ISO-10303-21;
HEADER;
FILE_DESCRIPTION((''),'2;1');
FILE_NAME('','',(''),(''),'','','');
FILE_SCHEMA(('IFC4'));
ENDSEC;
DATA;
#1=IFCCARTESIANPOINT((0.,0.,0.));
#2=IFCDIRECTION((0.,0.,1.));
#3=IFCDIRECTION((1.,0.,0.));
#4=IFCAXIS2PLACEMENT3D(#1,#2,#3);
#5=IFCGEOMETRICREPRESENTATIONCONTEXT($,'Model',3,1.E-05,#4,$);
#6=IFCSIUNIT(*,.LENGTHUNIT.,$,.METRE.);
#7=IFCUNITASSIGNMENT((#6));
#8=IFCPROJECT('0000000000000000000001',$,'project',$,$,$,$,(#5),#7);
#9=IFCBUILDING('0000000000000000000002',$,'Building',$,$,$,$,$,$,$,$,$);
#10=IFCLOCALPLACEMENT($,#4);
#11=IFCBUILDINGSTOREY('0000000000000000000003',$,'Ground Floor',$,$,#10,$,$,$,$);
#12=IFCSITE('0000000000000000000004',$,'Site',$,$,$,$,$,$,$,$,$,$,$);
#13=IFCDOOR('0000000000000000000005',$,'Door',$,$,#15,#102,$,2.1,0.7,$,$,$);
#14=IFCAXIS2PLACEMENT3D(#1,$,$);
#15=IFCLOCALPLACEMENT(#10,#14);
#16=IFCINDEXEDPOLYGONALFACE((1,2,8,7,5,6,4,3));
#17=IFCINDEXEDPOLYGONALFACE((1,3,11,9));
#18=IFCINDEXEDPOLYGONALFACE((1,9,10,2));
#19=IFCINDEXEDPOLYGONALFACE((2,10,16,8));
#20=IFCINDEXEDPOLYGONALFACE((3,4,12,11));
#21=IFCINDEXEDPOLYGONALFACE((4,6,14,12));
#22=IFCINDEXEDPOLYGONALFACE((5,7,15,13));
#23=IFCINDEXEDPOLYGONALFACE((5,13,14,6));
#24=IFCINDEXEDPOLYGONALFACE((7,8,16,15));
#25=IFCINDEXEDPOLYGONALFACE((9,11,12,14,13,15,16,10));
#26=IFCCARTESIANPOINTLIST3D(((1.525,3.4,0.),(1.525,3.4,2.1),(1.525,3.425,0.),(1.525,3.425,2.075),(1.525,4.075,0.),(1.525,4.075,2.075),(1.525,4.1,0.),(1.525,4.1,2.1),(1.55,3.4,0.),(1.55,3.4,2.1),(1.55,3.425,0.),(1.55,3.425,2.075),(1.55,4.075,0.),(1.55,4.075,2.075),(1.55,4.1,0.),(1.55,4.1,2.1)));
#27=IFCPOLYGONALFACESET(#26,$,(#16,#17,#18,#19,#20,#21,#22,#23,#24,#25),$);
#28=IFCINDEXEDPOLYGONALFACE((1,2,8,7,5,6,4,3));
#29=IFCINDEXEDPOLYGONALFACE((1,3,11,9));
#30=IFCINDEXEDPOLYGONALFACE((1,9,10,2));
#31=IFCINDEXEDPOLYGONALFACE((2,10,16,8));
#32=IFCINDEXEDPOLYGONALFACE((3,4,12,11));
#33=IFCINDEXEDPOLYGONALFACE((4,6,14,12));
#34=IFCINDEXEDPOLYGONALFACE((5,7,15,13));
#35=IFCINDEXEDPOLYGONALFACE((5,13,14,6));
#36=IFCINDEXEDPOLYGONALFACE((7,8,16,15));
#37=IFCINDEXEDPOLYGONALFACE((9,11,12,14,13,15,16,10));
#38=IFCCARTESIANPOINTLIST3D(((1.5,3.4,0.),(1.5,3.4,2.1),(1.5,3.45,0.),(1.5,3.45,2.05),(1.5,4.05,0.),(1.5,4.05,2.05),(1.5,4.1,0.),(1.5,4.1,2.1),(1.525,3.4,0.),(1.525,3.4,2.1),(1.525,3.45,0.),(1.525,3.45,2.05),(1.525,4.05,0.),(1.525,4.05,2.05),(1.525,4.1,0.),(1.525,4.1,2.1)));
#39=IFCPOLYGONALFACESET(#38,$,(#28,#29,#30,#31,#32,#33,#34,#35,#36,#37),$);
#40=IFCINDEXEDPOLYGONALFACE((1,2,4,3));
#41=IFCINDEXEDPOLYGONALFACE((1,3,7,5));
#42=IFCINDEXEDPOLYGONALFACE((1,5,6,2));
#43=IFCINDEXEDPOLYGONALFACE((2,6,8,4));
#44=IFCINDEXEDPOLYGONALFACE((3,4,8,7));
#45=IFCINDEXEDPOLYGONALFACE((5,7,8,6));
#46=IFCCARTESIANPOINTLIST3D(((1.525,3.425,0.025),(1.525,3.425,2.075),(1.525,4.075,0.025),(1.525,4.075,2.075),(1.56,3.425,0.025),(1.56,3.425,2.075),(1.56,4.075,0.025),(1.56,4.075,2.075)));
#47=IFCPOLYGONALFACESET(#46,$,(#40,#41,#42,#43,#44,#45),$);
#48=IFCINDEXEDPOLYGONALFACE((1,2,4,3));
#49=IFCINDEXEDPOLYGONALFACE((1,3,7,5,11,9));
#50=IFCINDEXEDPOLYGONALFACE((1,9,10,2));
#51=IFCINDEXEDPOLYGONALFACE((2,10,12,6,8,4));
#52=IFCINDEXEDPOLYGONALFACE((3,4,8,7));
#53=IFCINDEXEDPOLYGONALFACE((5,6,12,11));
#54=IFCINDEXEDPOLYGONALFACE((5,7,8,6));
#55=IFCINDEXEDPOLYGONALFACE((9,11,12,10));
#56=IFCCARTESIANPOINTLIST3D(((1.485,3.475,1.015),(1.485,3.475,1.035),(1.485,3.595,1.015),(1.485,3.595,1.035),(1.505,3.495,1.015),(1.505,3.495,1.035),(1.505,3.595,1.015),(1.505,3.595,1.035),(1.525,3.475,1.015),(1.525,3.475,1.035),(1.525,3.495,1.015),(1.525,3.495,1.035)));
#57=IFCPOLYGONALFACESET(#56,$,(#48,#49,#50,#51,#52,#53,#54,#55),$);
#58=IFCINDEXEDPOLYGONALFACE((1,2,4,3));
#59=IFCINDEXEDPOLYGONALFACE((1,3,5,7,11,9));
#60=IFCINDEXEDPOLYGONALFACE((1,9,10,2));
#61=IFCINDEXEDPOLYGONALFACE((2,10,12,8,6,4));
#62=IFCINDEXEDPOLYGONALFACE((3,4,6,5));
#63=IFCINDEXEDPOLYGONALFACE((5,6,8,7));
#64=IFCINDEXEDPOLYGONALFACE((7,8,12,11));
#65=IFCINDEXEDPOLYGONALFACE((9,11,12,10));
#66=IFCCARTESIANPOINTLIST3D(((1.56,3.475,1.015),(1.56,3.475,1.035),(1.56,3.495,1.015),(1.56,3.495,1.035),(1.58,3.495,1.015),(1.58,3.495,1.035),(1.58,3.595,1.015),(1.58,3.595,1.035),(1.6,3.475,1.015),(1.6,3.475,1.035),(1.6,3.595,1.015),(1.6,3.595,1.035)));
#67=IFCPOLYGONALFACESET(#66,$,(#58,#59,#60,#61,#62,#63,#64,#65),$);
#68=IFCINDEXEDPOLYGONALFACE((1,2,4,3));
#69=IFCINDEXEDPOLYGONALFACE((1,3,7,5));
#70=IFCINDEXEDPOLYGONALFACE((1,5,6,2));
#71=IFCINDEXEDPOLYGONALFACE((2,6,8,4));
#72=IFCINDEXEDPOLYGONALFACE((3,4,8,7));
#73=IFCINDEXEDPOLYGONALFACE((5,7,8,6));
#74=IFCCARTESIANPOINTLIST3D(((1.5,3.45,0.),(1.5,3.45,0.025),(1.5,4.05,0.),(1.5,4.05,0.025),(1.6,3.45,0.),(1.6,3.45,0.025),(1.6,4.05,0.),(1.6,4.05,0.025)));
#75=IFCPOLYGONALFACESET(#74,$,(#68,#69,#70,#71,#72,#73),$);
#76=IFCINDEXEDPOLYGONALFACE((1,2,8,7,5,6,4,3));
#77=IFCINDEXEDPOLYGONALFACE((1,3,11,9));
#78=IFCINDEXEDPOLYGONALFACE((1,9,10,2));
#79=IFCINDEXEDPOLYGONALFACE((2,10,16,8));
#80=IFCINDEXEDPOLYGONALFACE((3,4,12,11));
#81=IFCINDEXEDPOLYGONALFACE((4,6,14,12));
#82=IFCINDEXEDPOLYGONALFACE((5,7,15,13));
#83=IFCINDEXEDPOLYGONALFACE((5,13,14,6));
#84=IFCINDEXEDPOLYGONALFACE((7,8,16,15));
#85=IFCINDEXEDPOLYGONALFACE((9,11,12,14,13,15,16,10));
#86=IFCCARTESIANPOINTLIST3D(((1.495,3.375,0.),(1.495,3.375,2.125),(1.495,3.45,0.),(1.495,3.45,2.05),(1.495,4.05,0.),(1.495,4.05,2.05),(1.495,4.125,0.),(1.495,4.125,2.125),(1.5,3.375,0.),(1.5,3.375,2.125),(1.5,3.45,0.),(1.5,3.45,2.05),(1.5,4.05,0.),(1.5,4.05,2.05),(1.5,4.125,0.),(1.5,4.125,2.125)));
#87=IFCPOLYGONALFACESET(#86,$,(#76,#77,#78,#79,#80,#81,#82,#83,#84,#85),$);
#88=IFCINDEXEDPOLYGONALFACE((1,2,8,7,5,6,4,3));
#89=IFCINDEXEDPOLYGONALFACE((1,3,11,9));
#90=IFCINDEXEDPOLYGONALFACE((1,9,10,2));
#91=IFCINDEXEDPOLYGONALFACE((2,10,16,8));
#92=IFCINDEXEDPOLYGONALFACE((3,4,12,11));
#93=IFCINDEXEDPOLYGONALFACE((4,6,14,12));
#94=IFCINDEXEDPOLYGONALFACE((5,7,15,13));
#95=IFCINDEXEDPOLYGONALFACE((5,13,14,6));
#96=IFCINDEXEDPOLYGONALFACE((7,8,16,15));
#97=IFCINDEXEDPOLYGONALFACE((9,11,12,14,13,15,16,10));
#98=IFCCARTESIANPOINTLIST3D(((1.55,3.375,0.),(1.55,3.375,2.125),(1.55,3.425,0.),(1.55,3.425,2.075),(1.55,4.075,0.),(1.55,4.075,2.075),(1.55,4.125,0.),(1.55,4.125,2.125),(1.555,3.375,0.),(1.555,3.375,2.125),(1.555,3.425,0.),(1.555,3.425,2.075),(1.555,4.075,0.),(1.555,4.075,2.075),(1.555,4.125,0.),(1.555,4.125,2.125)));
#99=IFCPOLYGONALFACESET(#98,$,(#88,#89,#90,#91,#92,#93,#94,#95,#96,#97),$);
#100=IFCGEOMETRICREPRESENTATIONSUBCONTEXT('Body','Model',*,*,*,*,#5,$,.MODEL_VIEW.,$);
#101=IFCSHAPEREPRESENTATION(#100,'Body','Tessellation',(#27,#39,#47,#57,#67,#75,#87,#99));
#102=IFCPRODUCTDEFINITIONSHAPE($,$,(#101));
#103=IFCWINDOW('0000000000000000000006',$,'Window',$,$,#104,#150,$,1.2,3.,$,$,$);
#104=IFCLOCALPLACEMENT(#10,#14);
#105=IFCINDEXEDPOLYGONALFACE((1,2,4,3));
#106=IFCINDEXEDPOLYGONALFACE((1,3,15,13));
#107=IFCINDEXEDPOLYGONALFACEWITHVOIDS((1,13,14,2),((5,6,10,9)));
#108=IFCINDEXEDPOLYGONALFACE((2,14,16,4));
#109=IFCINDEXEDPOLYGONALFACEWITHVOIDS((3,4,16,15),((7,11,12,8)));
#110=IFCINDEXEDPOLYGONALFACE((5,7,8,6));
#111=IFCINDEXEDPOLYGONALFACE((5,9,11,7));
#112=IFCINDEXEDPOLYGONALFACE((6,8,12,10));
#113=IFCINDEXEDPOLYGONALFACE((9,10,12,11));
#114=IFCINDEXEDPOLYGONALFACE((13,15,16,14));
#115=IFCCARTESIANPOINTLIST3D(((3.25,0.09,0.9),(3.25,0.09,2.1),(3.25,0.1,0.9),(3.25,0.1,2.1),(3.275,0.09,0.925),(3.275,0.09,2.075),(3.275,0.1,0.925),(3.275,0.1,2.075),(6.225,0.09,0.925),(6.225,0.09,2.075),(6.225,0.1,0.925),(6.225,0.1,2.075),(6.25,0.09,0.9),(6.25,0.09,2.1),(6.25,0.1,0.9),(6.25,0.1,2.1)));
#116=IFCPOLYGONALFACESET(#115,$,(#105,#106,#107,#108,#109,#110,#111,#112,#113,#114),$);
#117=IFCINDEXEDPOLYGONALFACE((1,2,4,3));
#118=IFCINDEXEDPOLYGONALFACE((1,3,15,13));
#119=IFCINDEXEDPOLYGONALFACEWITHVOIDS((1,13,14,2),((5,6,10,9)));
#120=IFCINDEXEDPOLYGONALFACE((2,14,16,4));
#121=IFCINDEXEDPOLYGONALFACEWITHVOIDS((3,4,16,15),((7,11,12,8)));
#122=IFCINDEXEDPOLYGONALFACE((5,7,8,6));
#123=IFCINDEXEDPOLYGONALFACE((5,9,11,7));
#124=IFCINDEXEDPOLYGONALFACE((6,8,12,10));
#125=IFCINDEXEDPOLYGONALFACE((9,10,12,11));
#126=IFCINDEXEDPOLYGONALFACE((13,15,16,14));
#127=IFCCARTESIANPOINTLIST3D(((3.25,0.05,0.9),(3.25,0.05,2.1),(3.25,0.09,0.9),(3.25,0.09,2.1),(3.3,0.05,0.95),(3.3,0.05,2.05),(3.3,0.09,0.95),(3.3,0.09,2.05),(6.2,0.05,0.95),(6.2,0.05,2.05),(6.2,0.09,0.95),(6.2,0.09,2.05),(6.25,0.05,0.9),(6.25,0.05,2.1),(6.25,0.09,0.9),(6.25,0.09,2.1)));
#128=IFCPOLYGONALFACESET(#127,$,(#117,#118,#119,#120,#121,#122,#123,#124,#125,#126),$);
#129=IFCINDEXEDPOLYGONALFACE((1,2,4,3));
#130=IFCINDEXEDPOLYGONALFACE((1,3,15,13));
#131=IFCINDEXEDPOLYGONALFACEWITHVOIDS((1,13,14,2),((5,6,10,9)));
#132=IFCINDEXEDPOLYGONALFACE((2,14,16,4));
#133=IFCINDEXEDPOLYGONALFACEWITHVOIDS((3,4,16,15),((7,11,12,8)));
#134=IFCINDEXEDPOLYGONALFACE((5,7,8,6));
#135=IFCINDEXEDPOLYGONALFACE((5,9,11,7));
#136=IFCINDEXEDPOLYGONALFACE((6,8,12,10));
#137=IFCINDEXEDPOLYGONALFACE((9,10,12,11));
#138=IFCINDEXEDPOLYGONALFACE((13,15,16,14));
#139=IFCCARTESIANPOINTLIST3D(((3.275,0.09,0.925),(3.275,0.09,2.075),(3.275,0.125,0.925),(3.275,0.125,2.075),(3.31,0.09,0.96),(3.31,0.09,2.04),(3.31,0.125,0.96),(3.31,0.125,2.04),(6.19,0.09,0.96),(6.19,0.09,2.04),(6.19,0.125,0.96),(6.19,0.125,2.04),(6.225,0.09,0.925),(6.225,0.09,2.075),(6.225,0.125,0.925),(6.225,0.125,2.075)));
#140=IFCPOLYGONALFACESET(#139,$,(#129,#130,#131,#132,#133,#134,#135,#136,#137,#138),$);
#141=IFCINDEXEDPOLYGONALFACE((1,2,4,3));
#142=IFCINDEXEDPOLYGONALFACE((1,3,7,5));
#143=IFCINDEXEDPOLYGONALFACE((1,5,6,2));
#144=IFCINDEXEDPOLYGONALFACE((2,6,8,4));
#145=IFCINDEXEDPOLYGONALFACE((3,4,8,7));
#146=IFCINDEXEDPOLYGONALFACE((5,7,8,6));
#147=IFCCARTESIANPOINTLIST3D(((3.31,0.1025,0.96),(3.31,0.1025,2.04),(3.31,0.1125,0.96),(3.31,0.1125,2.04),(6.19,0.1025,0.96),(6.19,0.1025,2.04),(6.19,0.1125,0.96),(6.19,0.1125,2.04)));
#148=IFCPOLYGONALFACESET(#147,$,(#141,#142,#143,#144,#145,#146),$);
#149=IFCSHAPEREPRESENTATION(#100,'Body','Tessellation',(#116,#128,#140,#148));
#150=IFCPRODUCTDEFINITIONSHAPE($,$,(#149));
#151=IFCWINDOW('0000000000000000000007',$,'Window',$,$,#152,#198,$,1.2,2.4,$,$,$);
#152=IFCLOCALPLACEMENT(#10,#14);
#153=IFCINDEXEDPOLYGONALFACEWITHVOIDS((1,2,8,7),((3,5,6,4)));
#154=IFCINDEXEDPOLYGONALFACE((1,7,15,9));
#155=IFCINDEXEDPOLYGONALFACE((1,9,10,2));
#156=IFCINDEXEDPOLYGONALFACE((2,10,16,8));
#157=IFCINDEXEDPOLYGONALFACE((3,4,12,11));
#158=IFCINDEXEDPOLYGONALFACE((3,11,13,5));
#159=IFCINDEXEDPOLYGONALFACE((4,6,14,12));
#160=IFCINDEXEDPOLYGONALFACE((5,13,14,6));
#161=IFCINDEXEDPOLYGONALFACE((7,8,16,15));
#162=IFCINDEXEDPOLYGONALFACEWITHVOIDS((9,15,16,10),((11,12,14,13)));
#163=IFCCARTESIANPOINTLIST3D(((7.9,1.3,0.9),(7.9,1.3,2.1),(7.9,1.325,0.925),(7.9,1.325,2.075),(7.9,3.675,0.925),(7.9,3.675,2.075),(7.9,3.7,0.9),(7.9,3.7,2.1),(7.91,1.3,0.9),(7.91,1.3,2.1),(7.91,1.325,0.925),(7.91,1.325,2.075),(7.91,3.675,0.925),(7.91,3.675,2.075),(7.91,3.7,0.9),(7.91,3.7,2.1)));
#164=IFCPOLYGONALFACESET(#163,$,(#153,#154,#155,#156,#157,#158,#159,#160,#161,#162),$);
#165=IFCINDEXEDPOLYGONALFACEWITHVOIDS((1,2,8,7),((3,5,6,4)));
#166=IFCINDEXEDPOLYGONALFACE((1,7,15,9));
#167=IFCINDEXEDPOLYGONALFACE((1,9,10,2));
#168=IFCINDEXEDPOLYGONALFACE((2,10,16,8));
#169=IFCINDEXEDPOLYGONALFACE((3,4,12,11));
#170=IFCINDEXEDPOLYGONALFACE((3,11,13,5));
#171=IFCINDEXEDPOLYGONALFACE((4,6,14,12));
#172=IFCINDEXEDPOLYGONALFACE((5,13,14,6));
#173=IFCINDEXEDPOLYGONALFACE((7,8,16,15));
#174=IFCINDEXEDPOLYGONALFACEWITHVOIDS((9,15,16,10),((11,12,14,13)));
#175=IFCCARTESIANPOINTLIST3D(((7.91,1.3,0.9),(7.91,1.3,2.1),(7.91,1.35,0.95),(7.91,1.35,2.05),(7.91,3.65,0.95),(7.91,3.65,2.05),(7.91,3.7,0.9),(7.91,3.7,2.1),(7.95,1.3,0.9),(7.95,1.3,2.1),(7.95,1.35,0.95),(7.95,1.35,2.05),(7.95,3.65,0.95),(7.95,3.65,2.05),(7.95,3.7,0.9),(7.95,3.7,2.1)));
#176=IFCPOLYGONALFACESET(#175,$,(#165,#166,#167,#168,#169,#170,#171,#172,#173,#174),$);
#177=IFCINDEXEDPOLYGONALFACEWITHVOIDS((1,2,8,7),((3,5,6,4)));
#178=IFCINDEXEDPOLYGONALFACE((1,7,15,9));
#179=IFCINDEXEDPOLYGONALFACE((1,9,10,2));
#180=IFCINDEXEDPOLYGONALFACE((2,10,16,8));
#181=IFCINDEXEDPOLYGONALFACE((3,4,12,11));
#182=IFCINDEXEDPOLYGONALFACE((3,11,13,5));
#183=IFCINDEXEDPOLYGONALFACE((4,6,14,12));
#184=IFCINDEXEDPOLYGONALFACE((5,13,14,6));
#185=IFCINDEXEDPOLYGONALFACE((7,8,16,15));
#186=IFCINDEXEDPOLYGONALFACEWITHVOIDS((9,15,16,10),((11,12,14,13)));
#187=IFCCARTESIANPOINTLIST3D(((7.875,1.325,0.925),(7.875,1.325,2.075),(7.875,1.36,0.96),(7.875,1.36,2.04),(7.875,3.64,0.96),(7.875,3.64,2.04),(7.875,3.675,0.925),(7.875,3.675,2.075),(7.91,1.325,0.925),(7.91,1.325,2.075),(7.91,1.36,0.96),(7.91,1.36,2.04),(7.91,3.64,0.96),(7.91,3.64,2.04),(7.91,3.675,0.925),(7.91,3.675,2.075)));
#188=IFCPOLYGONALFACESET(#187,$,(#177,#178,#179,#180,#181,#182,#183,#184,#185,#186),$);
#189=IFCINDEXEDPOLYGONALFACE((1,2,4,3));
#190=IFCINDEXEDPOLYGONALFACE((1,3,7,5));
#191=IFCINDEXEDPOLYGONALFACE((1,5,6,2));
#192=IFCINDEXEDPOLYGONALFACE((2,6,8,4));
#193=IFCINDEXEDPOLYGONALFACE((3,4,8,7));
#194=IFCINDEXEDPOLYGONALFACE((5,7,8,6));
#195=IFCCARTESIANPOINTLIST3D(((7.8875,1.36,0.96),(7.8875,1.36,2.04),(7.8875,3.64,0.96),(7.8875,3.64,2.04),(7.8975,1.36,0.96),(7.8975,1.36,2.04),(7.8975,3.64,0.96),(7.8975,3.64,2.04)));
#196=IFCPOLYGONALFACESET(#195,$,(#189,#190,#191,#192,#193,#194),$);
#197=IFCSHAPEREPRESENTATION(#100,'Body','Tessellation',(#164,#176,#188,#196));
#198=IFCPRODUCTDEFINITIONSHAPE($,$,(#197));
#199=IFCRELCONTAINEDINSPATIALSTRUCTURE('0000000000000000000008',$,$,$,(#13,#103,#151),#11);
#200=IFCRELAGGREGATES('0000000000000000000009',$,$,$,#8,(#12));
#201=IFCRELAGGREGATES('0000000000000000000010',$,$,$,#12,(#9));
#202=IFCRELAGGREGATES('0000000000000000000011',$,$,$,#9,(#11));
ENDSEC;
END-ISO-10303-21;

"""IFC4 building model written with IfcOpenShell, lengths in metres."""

from ifc_helpers import new_model, si_unit, frame, origin_with_axes, place, context, subcontext, project, spatial, line, indexed_curve, outline, extrude, element, save


model = new_model("IFC4")

# Units and contexts
model_context = context("Model", 3, precision=1e-05, world=origin_with_axes())
body_context = subcontext(model_context, "Body", "Model", "MODEL_VIEW")
ifc_project = project(units=[si_unit("LENGTHUNIT", "METRE")], contexts=[model_context])

# Site, building, storey
site = spatial("IfcSite", under=ifc_project, Name="Site")
building = spatial("IfcBuilding", under=site, Name="Building")
storey_placement = place(None, origin_with_axes())
storey = spatial("IfcBuildingStorey", under=building, at=storey_placement, Name="Ground Floor")

# Door
door_1_placement = place(storey_placement, frame((1.5, 4.1, 0.0), z_axis=(0.0, 0.0, 1.0), x_axis=(0.0, -1.0, 0.0)))
element("IfcDoor", 1, at=door_1_placement, inside=storey, Name="Door", OverallHeight=2.1, OverallWidth=0.7, context=body_context, shape_type="SweptSolid", body=[
    extrude(outline(indexed_curve([(0.0, 0.0), (0.0, 2.1), (0.7, 2.1), (0.7, 0.0), (0.675, 0.0), (0.675, 2.075), (0.025, 2.075), (0.025, 0.0)], segments=[line(1, 2, 3, 4, 5, 6, 7, 8, 1)])), frame((0.0, 0.025, 0.0), z_axis=(0.0, -1.0, 0.0), x_axis=(1.0, 0.0, 0.0)), (0.0, 0.0, -1.0), 0.025),
    extrude(outline(indexed_curve([(0.0, 0.0), (0.0, 2.1), (0.7, 2.1), (0.7, 0.0), (0.65, 0.0), (0.65, 2.05), (0.05, 2.05), (0.05, 0.0)], segments=[line(1, 2, 3, 4, 5, 6, 7, 8, 1)])), frame((0.0, 0.0, 0.0), z_axis=(0.0, -1.0, 0.0), x_axis=(1.0, 0.0, 0.0)), (0.0, 0.0, -1.0), 0.025),
    extrude(outline(indexed_curve([(0.0, 0.0), (0.65, 0.0), (0.65, 0.035), (0.0, 0.035)], segments=[line(1, 2, 3, 4, 1)])), frame((0.025, 0.025, 0.025), z_axis=(0.0, 0.0, 1.0), x_axis=(1.0, 0.0, 0.0)), (0.0, 0.0, 1.0), 2.05),
    extrude(outline(indexed_curve([(0.0, 0.0), (0.0, -0.04), (-0.12, -0.04), (-0.12, -0.02), (-0.02, -0.02), (-0.02, 0.0)], segments=[line(1, 2, 3, 4, 5, 6, 1)])), frame((0.625, 0.025, 1.015), z_axis=(0.0, 0.0, 1.0), x_axis=(1.0, 0.0, 0.0)), (0.0, 0.0, 1.0), 0.02),
    extrude(outline(indexed_curve([(0.0, 0.0), (0.0, 0.04), (-0.12, 0.04), (-0.12, 0.02), (-0.02, 0.02), (-0.02, 0.0)], segments=[line(1, 2, 3, 4, 5, 6, 1)])), frame((0.625, 0.06, 1.015), z_axis=(0.0, 0.0, 1.0), x_axis=(1.0, 0.0, 0.0)), (0.0, 0.0, 1.0), 0.02),
    extrude(outline(indexed_curve([(0.0, 0.0), (0.6, 0.0), (0.6, 0.1), (0.0, 0.1)], segments=[line(1, 2, 3, 4, 1)])), frame((0.05, 0.0, 0.0), z_axis=(0.0, 0.0, 1.0), x_axis=(1.0, 0.0, 0.0)), (0.0, 0.0, 1.0), 0.025),
    extrude(outline(indexed_curve([(0.0, 0.0), (0.0, 2.125), (0.75, 2.125), (0.75, 0.0), (0.675, 0.0), (0.675, 2.05), (0.075, 2.05), (0.075, 0.0)], segments=[line(1, 2, 3, 4, 5, 6, 7, 8, 1)])), frame((-0.025, -0.005, 0.0), z_axis=(0.0, -1.0, 0.0), x_axis=(1.0, 0.0, 0.0)), (0.0, 0.0, -1.0), 0.005),
    extrude(outline(indexed_curve([(0.0, 0.0), (0.0, 2.125), (0.75, 2.125), (0.75, 0.0), (0.7, 0.0), (0.7, 2.075), (0.05, 2.075), (0.05, 0.0)], segments=[line(1, 2, 3, 4, 5, 6, 7, 8, 1)])), frame((-0.025, 0.05, 0.0), z_axis=(0.0, -1.0, 0.0), x_axis=(1.0, 0.0, 0.0)), (0.0, 0.0, -1.0), 0.005),
])

# Windows
window_1_placement = place(storey_placement, frame((3.25, 0.0, 0.9), z_axis=(0.0, 0.0, 1.0), x_axis=(1.0, 0.0, 0.0)))
element("IfcWindow", 2, at=window_1_placement, inside=storey, Name="Window", OverallHeight=1.2, OverallWidth=3.0, context=body_context, shape_type="SweptSolid", body=[
    extrude(outline(indexed_curve([(0.0, 0.0), (3.0, 0.0), (3.0, 1.2), (0.0, 1.2)], segments=[line(1, 2, 3, 4, 1)]), holes=[indexed_curve([(0.025, 0.025), (2.975, 0.025), (2.975, 1.175), (0.025, 1.175)], segments=[line(1, 2, 3, 4, 1)])]), frame((0.0, 0.09, 0.0), z_axis=(0.0, -1.0, 0.0), x_axis=(1.0, 0.0, 0.0)), (0.0, 0.0, -1.0), 0.01),
    extrude(outline(indexed_curve([(0.0, 0.0), (3.0, 0.0), (3.0, 1.2), (0.0, 1.2)], segments=[line(1, 2, 3, 4, 1)]), holes=[indexed_curve([(0.05, 0.05), (2.95, 0.05), (2.95, 1.15), (0.05, 1.15)], segments=[line(1, 2, 3, 4, 1)])]), frame((0.0, 0.05, 0.0), z_axis=(0.0, -1.0, 0.0), x_axis=(1.0, 0.0, 0.0)), (0.0, 0.0, -1.0), 0.04),
    extrude(outline(indexed_curve([(0.0, 0.0), (2.95, 0.0), (2.95, 1.15), (0.0, 1.15)], segments=[line(1, 2, 3, 4, 1)]), holes=[indexed_curve([(0.035, 0.035), (2.915, 0.035), (2.915, 1.115), (0.035, 1.115)], segments=[line(1, 2, 3, 4, 1)])]), frame((0.025, 0.09, 0.025), z_axis=(0.0, -1.0, 0.0), x_axis=(1.0, 0.0, 0.0)), (0.0, 0.0, -1.0), 0.035),
    extrude(outline(indexed_curve([(0.035, 0.035), (2.915, 0.035), (2.915, 1.115), (0.035, 1.115)], segments=[line(1, 2, 3, 4, 1)])), frame((0.025, 0.1025, 0.025), z_axis=(0.0, -1.0, 0.0), x_axis=(1.0, 0.0, 0.0)), (0.0, 0.0, -1.0), 0.01),
])
window_2_placement = place(storey_placement, frame((8.0, 1.3, 0.9), z_axis=(0.0, 0.0, 1.0), x_axis=(0.0, 1.0, 0.0)))
element("IfcWindow", 3, at=window_2_placement, inside=storey, Name="Window", OverallHeight=1.2, OverallWidth=2.4, context=body_context, shape_type="SweptSolid", body=[
    extrude(outline(indexed_curve([(0.0, 0.0), (2.4, 0.0), (2.4, 1.2), (0.0, 1.2)], segments=[line(1, 2, 3, 4, 1)]), holes=[indexed_curve([(0.025, 0.025), (2.375, 0.025), (2.375, 1.175), (0.025, 1.175)], segments=[line(1, 2, 3, 4, 1)])]), frame((0.0, 0.09, 0.0), z_axis=(0.0, -1.0, 0.0), x_axis=(1.0, 0.0, 0.0)), (0.0, 0.0, -1.0), 0.01),
    extrude(outline(indexed_curve([(0.0, 0.0), (2.4, 0.0), (2.4, 1.2), (0.0, 1.2)], segments=[line(1, 2, 3, 4, 1)]), holes=[indexed_curve([(0.05, 0.05), (2.35, 0.05), (2.35, 1.15), (0.05, 1.15)], segments=[line(1, 2, 3, 4, 1)])]), frame((0.0, 0.05, 0.0), z_axis=(0.0, -1.0, 0.0), x_axis=(1.0, 0.0, 0.0)), (0.0, 0.0, -1.0), 0.04),
    extrude(outline(indexed_curve([(0.0, 0.0), (2.35, 0.0), (2.35, 1.15), (0.0, 1.15)], segments=[line(1, 2, 3, 4, 1)]), holes=[indexed_curve([(0.035, 0.035), (2.315, 0.035), (2.315, 1.115), (0.035, 1.115)], segments=[line(1, 2, 3, 4, 1)])]), frame((0.025, 0.09, 0.025), z_axis=(0.0, -1.0, 0.0), x_axis=(1.0, 0.0, 0.0)), (0.0, 0.0, -1.0), 0.035),
    extrude(outline(indexed_curve([(0.035, 0.035), (2.315, 0.035), (2.315, 1.115), (0.035, 1.115)], segments=[line(1, 2, 3, 4, 1)])), frame((0.025, 0.1025, 0.025), z_axis=(0.0, -1.0, 0.0), x_axis=(1.0, 0.0, 0.0)), (0.0, 0.0, -1.0), 0.01),
])

save(model, "model.ifc")
